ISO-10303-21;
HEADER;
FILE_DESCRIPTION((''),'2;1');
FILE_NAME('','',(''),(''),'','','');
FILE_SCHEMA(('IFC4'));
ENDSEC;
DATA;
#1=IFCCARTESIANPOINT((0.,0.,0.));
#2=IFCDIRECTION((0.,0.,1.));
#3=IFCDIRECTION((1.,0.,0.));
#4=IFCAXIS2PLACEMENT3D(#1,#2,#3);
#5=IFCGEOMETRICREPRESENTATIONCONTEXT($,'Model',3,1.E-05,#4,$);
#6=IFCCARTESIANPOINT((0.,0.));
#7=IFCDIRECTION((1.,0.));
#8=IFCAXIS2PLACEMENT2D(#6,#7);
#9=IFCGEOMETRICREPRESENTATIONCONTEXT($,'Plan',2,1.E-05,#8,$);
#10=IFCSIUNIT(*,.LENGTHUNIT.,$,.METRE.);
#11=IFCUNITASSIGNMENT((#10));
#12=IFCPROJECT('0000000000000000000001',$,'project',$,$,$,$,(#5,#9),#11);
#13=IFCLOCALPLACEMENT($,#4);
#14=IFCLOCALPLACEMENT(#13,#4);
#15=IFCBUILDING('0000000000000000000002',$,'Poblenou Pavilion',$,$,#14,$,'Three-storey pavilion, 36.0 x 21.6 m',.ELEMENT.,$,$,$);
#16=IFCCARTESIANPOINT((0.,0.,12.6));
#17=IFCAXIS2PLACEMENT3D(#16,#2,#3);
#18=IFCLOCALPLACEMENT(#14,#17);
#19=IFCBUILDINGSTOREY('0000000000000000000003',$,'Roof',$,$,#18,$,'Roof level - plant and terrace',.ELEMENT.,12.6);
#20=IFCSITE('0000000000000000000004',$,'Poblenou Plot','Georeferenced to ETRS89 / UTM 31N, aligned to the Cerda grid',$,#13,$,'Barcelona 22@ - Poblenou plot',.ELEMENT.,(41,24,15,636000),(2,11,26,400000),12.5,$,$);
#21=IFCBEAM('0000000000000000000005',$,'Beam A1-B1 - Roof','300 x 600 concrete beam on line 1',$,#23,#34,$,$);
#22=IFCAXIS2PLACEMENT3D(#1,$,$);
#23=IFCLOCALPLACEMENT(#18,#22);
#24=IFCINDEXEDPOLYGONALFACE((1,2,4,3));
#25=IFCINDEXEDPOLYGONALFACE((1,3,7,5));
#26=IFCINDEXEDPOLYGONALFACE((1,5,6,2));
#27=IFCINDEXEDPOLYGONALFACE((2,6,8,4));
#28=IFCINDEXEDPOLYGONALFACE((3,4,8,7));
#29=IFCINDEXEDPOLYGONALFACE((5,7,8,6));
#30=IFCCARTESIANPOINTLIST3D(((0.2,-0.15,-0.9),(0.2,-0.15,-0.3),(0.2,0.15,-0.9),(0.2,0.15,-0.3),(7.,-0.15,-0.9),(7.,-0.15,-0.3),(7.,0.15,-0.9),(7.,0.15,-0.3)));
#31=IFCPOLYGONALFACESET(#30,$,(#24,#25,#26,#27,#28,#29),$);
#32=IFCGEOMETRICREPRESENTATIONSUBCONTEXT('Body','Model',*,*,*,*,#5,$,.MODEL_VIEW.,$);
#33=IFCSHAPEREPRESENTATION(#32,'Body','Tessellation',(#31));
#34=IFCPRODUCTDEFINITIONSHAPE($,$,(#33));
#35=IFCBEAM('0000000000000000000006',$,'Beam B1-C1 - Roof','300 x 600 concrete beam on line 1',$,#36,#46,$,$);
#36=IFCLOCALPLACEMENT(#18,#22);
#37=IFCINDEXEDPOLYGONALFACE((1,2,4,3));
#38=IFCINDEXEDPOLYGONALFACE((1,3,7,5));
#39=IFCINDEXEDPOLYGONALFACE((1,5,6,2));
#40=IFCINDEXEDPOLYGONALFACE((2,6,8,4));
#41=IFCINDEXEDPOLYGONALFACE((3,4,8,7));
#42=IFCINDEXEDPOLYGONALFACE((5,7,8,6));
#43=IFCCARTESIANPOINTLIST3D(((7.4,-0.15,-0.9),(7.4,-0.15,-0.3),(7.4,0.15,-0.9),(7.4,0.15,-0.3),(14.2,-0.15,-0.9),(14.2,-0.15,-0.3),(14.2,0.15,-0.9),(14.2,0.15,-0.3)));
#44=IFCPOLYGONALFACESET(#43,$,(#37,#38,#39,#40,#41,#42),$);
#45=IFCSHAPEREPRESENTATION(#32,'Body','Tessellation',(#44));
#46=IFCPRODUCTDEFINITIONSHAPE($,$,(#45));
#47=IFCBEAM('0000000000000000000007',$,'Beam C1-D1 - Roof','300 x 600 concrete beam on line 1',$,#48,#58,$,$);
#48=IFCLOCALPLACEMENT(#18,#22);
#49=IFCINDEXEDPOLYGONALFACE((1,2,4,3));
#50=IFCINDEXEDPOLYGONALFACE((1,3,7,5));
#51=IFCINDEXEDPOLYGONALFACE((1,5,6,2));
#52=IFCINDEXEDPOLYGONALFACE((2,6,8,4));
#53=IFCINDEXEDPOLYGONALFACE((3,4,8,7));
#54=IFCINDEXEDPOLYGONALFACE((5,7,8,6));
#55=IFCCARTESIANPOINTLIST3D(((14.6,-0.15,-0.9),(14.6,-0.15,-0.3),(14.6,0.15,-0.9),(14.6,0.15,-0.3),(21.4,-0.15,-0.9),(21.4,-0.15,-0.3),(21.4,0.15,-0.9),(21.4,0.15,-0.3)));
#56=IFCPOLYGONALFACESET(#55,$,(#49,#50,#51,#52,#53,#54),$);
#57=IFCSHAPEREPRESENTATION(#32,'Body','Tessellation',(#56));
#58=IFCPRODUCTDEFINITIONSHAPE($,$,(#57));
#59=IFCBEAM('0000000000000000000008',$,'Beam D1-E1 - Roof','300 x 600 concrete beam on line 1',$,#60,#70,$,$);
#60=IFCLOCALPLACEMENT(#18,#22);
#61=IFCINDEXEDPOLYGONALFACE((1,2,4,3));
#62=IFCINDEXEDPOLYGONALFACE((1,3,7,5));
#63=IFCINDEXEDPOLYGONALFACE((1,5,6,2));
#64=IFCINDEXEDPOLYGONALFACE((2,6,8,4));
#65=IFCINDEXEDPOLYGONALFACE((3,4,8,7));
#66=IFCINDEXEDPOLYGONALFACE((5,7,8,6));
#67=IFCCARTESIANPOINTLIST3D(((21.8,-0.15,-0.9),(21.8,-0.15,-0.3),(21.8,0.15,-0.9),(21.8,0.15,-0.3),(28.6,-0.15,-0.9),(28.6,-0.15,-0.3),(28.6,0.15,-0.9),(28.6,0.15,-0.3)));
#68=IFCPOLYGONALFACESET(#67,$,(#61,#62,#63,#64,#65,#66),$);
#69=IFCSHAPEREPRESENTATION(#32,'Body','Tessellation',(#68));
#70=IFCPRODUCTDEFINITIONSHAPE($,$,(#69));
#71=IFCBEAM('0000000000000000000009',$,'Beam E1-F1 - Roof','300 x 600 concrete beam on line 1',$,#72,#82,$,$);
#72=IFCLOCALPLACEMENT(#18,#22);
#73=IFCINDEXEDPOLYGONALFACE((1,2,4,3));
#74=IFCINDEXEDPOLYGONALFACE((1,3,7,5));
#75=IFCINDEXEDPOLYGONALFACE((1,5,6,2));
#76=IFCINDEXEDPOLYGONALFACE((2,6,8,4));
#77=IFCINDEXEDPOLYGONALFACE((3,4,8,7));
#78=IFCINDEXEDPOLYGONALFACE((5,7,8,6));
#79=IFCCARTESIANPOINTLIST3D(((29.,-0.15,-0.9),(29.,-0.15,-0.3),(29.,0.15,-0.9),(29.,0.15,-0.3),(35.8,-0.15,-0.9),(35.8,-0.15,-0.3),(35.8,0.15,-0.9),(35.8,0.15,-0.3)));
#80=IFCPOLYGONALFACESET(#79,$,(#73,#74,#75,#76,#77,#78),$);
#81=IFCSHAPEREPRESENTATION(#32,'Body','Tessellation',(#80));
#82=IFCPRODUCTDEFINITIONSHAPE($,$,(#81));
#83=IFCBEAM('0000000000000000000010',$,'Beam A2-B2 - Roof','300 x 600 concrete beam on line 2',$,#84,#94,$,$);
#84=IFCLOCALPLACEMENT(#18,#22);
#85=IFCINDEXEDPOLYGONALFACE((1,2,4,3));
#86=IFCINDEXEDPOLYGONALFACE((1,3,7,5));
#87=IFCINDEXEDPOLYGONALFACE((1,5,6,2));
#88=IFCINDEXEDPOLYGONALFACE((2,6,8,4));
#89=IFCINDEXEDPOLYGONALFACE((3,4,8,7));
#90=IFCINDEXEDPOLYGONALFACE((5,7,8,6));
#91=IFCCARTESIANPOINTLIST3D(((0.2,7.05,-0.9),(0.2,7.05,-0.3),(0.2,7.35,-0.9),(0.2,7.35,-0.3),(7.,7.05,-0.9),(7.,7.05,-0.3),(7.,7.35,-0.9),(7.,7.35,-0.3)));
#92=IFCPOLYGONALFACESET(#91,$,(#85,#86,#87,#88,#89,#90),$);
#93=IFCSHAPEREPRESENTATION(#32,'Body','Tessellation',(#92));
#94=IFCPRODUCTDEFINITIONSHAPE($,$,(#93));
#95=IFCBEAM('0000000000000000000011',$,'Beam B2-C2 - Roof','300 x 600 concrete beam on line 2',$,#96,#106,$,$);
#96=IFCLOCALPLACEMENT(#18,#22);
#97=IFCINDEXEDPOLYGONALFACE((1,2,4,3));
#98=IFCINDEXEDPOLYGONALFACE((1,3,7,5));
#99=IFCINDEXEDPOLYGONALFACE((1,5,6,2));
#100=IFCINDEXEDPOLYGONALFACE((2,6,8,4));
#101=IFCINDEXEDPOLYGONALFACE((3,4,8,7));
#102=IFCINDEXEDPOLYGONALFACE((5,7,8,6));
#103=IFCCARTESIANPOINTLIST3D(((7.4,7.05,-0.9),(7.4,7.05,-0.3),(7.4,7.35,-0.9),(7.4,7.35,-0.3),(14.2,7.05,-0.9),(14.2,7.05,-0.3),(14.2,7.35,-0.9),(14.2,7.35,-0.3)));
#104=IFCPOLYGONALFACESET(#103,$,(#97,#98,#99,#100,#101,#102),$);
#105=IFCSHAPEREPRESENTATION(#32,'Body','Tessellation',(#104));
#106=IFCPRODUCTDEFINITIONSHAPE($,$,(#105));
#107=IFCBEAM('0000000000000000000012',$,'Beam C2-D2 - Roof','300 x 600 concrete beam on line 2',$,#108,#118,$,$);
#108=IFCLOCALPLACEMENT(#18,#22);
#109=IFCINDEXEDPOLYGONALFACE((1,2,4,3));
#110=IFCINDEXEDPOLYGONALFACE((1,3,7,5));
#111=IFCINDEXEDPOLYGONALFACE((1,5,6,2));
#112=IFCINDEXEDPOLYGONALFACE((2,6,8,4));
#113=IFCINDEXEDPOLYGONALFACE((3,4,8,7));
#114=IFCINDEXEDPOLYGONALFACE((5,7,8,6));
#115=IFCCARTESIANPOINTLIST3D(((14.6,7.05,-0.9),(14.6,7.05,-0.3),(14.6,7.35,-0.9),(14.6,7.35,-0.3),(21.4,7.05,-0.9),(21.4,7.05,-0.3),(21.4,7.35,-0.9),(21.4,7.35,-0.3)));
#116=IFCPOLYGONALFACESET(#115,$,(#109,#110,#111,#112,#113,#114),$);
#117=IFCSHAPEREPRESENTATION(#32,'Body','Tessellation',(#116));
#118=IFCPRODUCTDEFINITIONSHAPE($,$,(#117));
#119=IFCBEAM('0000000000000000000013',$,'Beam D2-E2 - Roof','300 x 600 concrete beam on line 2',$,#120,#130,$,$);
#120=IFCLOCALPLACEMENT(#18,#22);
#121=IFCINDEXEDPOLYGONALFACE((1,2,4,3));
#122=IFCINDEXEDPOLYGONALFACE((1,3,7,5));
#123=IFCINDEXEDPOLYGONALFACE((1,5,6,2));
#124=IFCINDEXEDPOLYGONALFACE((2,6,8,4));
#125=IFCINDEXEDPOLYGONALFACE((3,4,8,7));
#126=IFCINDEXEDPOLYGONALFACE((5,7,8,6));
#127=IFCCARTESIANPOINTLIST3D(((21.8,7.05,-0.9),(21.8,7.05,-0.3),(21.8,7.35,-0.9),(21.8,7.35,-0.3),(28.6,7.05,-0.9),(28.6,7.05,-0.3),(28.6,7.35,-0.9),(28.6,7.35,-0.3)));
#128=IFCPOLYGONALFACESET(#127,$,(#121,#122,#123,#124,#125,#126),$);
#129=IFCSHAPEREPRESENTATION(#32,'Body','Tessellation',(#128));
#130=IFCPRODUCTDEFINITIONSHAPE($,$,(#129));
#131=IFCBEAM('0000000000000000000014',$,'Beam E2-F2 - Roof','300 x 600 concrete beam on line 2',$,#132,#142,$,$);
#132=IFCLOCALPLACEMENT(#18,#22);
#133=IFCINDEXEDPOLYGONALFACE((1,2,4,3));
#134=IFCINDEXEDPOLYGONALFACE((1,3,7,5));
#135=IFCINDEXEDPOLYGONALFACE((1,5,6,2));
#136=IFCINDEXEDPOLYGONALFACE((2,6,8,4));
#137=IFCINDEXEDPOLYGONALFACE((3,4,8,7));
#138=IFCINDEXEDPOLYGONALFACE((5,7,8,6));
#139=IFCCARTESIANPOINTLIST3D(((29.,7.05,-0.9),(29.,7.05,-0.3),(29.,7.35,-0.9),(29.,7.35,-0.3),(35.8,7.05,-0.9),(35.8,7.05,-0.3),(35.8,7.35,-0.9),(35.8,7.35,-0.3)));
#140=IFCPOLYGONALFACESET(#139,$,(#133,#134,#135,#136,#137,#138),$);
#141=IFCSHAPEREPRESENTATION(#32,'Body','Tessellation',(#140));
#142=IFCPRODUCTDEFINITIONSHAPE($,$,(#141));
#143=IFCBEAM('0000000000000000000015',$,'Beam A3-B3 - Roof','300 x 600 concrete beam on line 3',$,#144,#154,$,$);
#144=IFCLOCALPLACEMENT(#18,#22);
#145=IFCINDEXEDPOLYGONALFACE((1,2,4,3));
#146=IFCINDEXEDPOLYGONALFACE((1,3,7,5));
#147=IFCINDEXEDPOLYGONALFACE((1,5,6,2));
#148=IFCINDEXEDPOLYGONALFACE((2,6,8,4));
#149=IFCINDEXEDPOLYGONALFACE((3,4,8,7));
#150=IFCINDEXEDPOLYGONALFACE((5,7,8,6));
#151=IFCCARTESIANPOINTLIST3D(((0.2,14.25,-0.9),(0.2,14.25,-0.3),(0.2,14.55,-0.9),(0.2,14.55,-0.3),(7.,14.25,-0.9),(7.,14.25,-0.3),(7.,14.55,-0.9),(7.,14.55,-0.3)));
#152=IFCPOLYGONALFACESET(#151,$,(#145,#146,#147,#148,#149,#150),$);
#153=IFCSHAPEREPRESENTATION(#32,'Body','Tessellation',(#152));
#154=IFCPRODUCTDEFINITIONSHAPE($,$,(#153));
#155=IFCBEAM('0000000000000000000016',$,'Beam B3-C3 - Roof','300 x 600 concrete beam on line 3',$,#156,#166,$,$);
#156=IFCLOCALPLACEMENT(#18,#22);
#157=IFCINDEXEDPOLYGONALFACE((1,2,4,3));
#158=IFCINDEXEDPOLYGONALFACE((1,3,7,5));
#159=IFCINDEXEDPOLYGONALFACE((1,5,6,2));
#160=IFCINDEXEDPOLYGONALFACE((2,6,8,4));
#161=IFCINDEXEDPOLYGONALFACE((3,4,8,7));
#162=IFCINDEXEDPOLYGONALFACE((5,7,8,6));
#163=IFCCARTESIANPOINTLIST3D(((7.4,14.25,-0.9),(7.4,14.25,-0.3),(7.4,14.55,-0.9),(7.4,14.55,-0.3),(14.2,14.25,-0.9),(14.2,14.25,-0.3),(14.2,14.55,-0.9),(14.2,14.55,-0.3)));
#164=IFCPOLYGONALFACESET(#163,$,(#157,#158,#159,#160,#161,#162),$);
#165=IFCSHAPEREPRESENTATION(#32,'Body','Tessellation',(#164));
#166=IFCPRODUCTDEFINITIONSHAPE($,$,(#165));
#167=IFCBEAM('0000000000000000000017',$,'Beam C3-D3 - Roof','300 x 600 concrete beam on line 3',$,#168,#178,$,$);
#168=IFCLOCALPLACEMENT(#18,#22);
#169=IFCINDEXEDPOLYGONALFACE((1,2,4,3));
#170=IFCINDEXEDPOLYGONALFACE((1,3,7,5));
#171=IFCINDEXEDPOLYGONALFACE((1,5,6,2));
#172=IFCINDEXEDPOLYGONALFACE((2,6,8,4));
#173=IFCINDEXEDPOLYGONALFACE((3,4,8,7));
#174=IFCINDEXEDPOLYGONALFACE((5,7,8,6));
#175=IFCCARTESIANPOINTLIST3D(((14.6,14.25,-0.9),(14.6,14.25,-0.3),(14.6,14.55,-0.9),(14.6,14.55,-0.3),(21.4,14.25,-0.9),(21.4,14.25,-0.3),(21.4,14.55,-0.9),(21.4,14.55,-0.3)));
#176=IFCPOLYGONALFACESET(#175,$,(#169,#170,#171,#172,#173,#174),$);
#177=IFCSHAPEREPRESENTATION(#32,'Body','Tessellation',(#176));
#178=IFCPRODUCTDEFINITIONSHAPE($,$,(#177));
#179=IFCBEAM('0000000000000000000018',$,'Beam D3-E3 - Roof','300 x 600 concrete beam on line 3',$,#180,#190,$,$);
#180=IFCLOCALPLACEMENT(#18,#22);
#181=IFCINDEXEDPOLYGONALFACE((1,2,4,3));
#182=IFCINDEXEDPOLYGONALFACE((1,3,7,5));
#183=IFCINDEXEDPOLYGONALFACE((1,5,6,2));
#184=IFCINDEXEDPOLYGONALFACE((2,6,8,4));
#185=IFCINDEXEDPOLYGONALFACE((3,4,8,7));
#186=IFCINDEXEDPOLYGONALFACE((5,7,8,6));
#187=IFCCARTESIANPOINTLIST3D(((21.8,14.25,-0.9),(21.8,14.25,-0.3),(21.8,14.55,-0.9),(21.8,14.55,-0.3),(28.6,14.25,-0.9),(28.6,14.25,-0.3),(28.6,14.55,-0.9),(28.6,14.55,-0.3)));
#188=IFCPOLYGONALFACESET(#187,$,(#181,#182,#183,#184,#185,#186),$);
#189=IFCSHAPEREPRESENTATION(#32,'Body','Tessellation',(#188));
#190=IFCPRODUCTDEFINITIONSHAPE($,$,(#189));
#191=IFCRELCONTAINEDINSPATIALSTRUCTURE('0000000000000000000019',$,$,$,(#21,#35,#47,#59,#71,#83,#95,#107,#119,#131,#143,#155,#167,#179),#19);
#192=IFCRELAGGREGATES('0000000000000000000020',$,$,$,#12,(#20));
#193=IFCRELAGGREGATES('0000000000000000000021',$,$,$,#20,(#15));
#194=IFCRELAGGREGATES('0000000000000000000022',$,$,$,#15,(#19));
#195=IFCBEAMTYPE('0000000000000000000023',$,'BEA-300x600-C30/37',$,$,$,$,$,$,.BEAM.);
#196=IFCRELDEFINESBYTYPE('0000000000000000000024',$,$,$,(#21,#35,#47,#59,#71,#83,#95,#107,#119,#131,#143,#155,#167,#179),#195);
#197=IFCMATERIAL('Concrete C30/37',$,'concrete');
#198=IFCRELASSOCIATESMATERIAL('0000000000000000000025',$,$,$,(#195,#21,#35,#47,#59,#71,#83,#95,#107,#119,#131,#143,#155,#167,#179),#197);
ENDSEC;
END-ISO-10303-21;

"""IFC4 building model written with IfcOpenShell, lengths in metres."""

from ifc_helpers import new_model, si_unit, frame, origin_with_axes, origin_2d_with_axis, place, context, subcontext, project, spatial, line, indexed_curve, rectangle, outline, extrude, material, material_profile, profile_set, profile_usage, type_object, element, save


model = new_model("IFC4")

# Units and contexts
model_context = context("Model", 3, precision=1e-05, world=origin_with_axes())
plan_context = context("Plan", 2, precision=1e-05, world=origin_2d_with_axis())
body_context = subcontext(model_context, "Body", "Model", "MODEL_VIEW")
ifc_project = project(units=[si_unit("LENGTHUNIT", "METRE")], contexts=[model_context, plan_context])

# Site, building, storey
site_placement = place(None, origin_with_axes())
site = spatial("IfcSite", under=ifc_project, at=site_placement, Name="Poblenou Plot", Description="Georeferenced to ETRS89 / UTM 31N, aligned to the Cerda grid", LongName="Barcelona 22@ - Poblenou plot", CompositionType="ELEMENT", RefLatitude=(41, 24, 15, 636000), RefLongitude=(2, 11, 26, 400000), RefElevation=12.5)
building_placement = place(site_placement, origin_with_axes())
building = spatial("IfcBuilding", under=site, at=building_placement, Name="Poblenou Pavilion", LongName="Three-storey pavilion, 36.0 x 21.6 m", CompositionType="ELEMENT")
storey_placement = place(building_placement, frame((0.0, 0.0, 12.6), z_axis=(0.0, 0.0, 1.0), x_axis=(1.0, 0.0, 0.0)))
storey = spatial("IfcBuildingStorey", under=building, at=storey_placement, Name="Roof", LongName="Roof level - plant and terrace", CompositionType="ELEMENT", Elevation=12.6)

# Beams
ifc_material = material(Name="Concrete C30/37", Category="concrete")
ifc_material_profile = material_profile(ifc_material, rectangle(XDim=0.3, YDim=0.6))
ifc_profile_set = profile_set([ifc_material_profile], Name="BEA-300x600-C30/37")
ifc_profile_usage_1 = profile_usage(ifc_profile_set)
beam_type = type_object("IfcBeamType", Name="BEA-300x600-C30/37", PredefinedType="BEAM", material=ifc_profile_set)
beam_1_placement = place(storey_placement, frame((0.2, -0.15, -0.9), z_axis=(1.0, 0.0, 0.0), x_axis=(0.0, 1.0, 0.0)))
element("IfcBeam", 1, at=beam_1_placement, inside=storey, type_object=beam_type, material=ifc_profile_usage_1, Name="Beam A1-B1 - Roof", Description="300 x 600 concrete beam on line 1", context=body_context, shape_type="SweptSolid", body=[
    extrude(outline(indexed_curve([(0.0, 0.0), (0.3, 0.0), (0.3, 0.6), (0.0, 0.6)], segments=[line(1, 2, 3, 4, 1)])), origin_with_axes(), (0.0, 0.0, 1.0), 6.8),
])
ifc_profile_usage_2 = profile_usage(ifc_profile_set)
beam_2_placement = place(storey_placement, frame((7.4, -0.15, -0.9), z_axis=(1.0, 0.0, 0.0), x_axis=(0.0, 1.0, 0.0)))
element("IfcBeam", 2, at=beam_2_placement, inside=storey, type_object=beam_type, material=ifc_profile_usage_2, Name="Beam B1-C1 - Roof", Description="300 x 600 concrete beam on line 1", context=body_context, shape_type="SweptSolid", body=[
    extrude(outline(indexed_curve([(0.0, 0.0), (0.3, 0.0), (0.3, 0.6), (0.0, 0.6)], segments=[line(1, 2, 3, 4, 1)])), origin_with_axes(), (0.0, 0.0, 1.0), 6.8),
])
ifc_profile_usage_3 = profile_usage(ifc_profile_set)
beam_3_placement = place(storey_placement, frame((14.6, -0.15, -0.9), z_axis=(1.0, 0.0, 0.0), x_axis=(0.0, 1.0, 0.0)))
element("IfcBeam", 3, at=beam_3_placement, inside=storey, type_object=beam_type, material=ifc_profile_usage_3, Name="Beam C1-D1 - Roof", Description="300 x 600 concrete beam on line 1", context=body_context, shape_type="SweptSolid", body=[
    extrude(outline(indexed_curve([(0.0, 0.0), (0.3, 0.0), (0.3, 0.6), (0.0, 0.6)], segments=[line(1, 2, 3, 4, 1)])), origin_with_axes(), (0.0, 0.0, 1.0), 6.8),
])
ifc_profile_usage_4 = profile_usage(ifc_profile_set)
beam_4_placement = place(storey_placement, frame((21.8, -0.15, -0.9), z_axis=(1.0, 0.0, 0.0), x_axis=(0.0, 1.0, 0.0)))
element("IfcBeam", 4, at=beam_4_placement, inside=storey, type_object=beam_type, material=ifc_profile_usage_4, Name="Beam D1-E1 - Roof", Description="300 x 600 concrete beam on line 1", context=body_context, shape_type="SweptSolid", body=[
    extrude(outline(indexed_curve([(0.0, 0.0), (0.3, 0.0), (0.3, 0.6), (0.0, 0.6)], segments=[line(1, 2, 3, 4, 1)])), origin_with_axes(), (0.0, 0.0, 1.0), 6.8),
])
ifc_profile_usage_5 = profile_usage(ifc_profile_set)
beam_5_placement = place(storey_placement, frame((29.0, -0.15, -0.9), z_axis=(1.0, 0.0, 0.0), x_axis=(0.0, 1.0, 0.0)))
element("IfcBeam", 5, at=beam_5_placement, inside=storey, type_object=beam_type, material=ifc_profile_usage_5, Name="Beam E1-F1 - Roof", Description="300 x 600 concrete beam on line 1", context=body_context, shape_type="SweptSolid", body=[
    extrude(outline(indexed_curve([(0.0, 0.0), (0.3, 0.0), (0.3, 0.6), (0.0, 0.6)], segments=[line(1, 2, 3, 4, 1)])), origin_with_axes(), (0.0, 0.0, 1.0), 6.8),
])
ifc_profile_usage_6 = profile_usage(ifc_profile_set)
beam_6_placement = place(storey_placement, frame((0.2, 7.05, -0.9), z_axis=(1.0, 0.0, 0.0), x_axis=(0.0, 1.0, 0.0)))
element("IfcBeam", 6, at=beam_6_placement, inside=storey, type_object=beam_type, material=ifc_profile_usage_6, Name="Beam A2-B2 - Roof", Description="300 x 600 concrete beam on line 2", context=body_context, shape_type="SweptSolid", body=[
    extrude(outline(indexed_curve([(0.0, 0.0), (0.3, 0.0), (0.3, 0.6), (0.0, 0.6)], segments=[line(1, 2, 3, 4, 1)])), origin_with_axes(), (0.0, 0.0, 1.0), 6.8),
])
ifc_profile_usage_7 = profile_usage(ifc_profile_set)
beam_7_placement = place(storey_placement, frame((7.4, 7.05, -0.9), z_axis=(1.0, 0.0, 0.0), x_axis=(0.0, 1.0, 0.0)))
element("IfcBeam", 7, at=beam_7_placement, inside=storey, type_object=beam_type, material=ifc_profile_usage_7, Name="Beam B2-C2 - Roof", Description="300 x 600 concrete beam on line 2", context=body_context, shape_type="SweptSolid", body=[
    extrude(outline(indexed_curve([(0.0, 0.0), (0.3, 0.0), (0.3, 0.6), (0.0, 0.6)], segments=[line(1, 2, 3, 4, 1)])), origin_with_axes(), (0.0, 0.0, 1.0), 6.8),
])
ifc_profile_usage_8 = profile_usage(ifc_profile_set)
beam_8_placement = place(storey_placement, frame((14.6, 7.05, -0.9), z_axis=(1.0, 0.0, 0.0), x_axis=(0.0, 1.0, 0.0)))
element("IfcBeam", 8, at=beam_8_placement, inside=storey, type_object=beam_type, material=ifc_profile_usage_8, Name="Beam C2-D2 - Roof", Description="300 x 600 concrete beam on line 2", context=body_context, shape_type="SweptSolid", body=[
    extrude(outline(indexed_curve([(0.0, 0.0), (0.3, 0.0), (0.3, 0.6), (0.0, 0.6)], segments=[line(1, 2, 3, 4, 1)])), origin_with_axes(), (0.0, 0.0, 1.0), 6.8),
])
ifc_profile_usage_9 = profile_usage(ifc_profile_set)
beam_9_placement = place(storey_placement, frame((21.8, 7.05, -0.9), z_axis=(1.0, 0.0, 0.0), x_axis=(0.0, 1.0, 0.0)))
element("IfcBeam", 9, at=beam_9_placement, inside=storey, type_object=beam_type, material=ifc_profile_usage_9, Name="Beam D2-E2 - Roof", Description="300 x 600 concrete beam on line 2", context=body_context, shape_type="SweptSolid", body=[
    extrude(outline(indexed_curve([(0.0, 0.0), (0.3, 0.0), (0.3, 0.6), (0.0, 0.6)], segments=[line(1, 2, 3, 4, 1)])), origin_with_axes(), (0.0, 0.0, 1.0), 6.8),
])
ifc_profile_usage_10 = profile_usage(ifc_profile_set)
beam_10_placement = place(storey_placement, frame((29.0, 7.05, -0.9), z_axis=(1.0, 0.0, 0.0), x_axis=(0.0, 1.0, 0.0)))
element("IfcBeam", 10, at=beam_10_placement, inside=storey, type_object=beam_type, material=ifc_profile_usage_10, Name="Beam E2-F2 - Roof", Description="300 x 600 concrete beam on line 2", context=body_context, shape_type="SweptSolid", body=[
    extrude(outline(indexed_curve([(0.0, 0.0), (0.3, 0.0), (0.3, 0.6), (0.0, 0.6)], segments=[line(1, 2, 3, 4, 1)])), origin_with_axes(), (0.0, 0.0, 1.0), 6.8),
])
ifc_profile_usage_11 = profile_usage(ifc_profile_set)
beam_11_placement = place(storey_placement, frame((0.2, 14.25, -0.9), z_axis=(1.0, 0.0, 0.0), x_axis=(0.0, 1.0, 0.0)))
element("IfcBeam", 11, at=beam_11_placement, inside=storey, type_object=beam_type, material=ifc_profile_usage_11, Name="Beam A3-B3 - Roof", Description="300 x 600 concrete beam on line 3", context=body_context, shape_type="SweptSolid", body=[
    extrude(outline(indexed_curve([(0.0, 0.0), (0.3, 0.0), (0.3, 0.6), (0.0, 0.6)], segments=[line(1, 2, 3, 4, 1)])), origin_with_axes(), (0.0, 0.0, 1.0), 6.8),
])
ifc_profile_usage_12 = profile_usage(ifc_profile_set)
beam_12_placement = place(storey_placement, frame((7.4, 14.25, -0.9), z_axis=(1.0, 0.0, 0.0), x_axis=(0.0, 1.0, 0.0)))
element("IfcBeam", 12, at=beam_12_placement, inside=storey, type_object=beam_type, material=ifc_profile_usage_12, Name="Beam B3-C3 - Roof", Description="300 x 600 concrete beam on line 3", context=body_context, shape_type="SweptSolid", body=[
    extrude(outline(indexed_curve([(0.0, 0.0), (0.3, 0.0), (0.3, 0.6), (0.0, 0.6)], segments=[line(1, 2, 3, 4, 1)])), origin_with_axes(), (0.0, 0.0, 1.0), 6.8),
])
ifc_profile_usage_13 = profile_usage(ifc_profile_set)
beam_13_placement = place(storey_placement, frame((14.6, 14.25, -0.9), z_axis=(1.0, 0.0, 0.0), x_axis=(0.0, 1.0, 0.0)))
element("IfcBeam", 13, at=beam_13_placement, inside=storey, type_object=beam_type, material=ifc_profile_usage_13, Name="Beam C3-D3 - Roof", Description="300 x 600 concrete beam on line 3", context=body_context, shape_type="SweptSolid", body=[
    extrude(outline(indexed_curve([(0.0, 0.0), (0.3, 0.0), (0.3, 0.6), (0.0, 0.6)], segments=[line(1, 2, 3, 4, 1)])), origin_with_axes(), (0.0, 0.0, 1.0), 6.8),
])
ifc_profile_usage_14 = profile_usage(ifc_profile_set)
beam_14_placement = place(storey_placement, frame((21.8, 14.25, -0.9), z_axis=(1.0, 0.0, 0.0), x_axis=(0.0, 1.0, 0.0)))
element("IfcBeam", 14, at=beam_14_placement, inside=storey, type_object=beam_type, material=ifc_profile_usage_14, Name="Beam D3-E3 - Roof", Description="300 x 600 concrete beam on line 3", context=body_context, shape_type="SweptSolid", body=[
    extrude(outline(indexed_curve([(0.0, 0.0), (0.3, 0.0), (0.3, 0.6), (0.0, 0.6)], segments=[line(1, 2, 3, 4, 1)])), origin_with_axes(), (0.0, 0.0, 1.0), 6.8),
])

save(model, "model.ifc")
